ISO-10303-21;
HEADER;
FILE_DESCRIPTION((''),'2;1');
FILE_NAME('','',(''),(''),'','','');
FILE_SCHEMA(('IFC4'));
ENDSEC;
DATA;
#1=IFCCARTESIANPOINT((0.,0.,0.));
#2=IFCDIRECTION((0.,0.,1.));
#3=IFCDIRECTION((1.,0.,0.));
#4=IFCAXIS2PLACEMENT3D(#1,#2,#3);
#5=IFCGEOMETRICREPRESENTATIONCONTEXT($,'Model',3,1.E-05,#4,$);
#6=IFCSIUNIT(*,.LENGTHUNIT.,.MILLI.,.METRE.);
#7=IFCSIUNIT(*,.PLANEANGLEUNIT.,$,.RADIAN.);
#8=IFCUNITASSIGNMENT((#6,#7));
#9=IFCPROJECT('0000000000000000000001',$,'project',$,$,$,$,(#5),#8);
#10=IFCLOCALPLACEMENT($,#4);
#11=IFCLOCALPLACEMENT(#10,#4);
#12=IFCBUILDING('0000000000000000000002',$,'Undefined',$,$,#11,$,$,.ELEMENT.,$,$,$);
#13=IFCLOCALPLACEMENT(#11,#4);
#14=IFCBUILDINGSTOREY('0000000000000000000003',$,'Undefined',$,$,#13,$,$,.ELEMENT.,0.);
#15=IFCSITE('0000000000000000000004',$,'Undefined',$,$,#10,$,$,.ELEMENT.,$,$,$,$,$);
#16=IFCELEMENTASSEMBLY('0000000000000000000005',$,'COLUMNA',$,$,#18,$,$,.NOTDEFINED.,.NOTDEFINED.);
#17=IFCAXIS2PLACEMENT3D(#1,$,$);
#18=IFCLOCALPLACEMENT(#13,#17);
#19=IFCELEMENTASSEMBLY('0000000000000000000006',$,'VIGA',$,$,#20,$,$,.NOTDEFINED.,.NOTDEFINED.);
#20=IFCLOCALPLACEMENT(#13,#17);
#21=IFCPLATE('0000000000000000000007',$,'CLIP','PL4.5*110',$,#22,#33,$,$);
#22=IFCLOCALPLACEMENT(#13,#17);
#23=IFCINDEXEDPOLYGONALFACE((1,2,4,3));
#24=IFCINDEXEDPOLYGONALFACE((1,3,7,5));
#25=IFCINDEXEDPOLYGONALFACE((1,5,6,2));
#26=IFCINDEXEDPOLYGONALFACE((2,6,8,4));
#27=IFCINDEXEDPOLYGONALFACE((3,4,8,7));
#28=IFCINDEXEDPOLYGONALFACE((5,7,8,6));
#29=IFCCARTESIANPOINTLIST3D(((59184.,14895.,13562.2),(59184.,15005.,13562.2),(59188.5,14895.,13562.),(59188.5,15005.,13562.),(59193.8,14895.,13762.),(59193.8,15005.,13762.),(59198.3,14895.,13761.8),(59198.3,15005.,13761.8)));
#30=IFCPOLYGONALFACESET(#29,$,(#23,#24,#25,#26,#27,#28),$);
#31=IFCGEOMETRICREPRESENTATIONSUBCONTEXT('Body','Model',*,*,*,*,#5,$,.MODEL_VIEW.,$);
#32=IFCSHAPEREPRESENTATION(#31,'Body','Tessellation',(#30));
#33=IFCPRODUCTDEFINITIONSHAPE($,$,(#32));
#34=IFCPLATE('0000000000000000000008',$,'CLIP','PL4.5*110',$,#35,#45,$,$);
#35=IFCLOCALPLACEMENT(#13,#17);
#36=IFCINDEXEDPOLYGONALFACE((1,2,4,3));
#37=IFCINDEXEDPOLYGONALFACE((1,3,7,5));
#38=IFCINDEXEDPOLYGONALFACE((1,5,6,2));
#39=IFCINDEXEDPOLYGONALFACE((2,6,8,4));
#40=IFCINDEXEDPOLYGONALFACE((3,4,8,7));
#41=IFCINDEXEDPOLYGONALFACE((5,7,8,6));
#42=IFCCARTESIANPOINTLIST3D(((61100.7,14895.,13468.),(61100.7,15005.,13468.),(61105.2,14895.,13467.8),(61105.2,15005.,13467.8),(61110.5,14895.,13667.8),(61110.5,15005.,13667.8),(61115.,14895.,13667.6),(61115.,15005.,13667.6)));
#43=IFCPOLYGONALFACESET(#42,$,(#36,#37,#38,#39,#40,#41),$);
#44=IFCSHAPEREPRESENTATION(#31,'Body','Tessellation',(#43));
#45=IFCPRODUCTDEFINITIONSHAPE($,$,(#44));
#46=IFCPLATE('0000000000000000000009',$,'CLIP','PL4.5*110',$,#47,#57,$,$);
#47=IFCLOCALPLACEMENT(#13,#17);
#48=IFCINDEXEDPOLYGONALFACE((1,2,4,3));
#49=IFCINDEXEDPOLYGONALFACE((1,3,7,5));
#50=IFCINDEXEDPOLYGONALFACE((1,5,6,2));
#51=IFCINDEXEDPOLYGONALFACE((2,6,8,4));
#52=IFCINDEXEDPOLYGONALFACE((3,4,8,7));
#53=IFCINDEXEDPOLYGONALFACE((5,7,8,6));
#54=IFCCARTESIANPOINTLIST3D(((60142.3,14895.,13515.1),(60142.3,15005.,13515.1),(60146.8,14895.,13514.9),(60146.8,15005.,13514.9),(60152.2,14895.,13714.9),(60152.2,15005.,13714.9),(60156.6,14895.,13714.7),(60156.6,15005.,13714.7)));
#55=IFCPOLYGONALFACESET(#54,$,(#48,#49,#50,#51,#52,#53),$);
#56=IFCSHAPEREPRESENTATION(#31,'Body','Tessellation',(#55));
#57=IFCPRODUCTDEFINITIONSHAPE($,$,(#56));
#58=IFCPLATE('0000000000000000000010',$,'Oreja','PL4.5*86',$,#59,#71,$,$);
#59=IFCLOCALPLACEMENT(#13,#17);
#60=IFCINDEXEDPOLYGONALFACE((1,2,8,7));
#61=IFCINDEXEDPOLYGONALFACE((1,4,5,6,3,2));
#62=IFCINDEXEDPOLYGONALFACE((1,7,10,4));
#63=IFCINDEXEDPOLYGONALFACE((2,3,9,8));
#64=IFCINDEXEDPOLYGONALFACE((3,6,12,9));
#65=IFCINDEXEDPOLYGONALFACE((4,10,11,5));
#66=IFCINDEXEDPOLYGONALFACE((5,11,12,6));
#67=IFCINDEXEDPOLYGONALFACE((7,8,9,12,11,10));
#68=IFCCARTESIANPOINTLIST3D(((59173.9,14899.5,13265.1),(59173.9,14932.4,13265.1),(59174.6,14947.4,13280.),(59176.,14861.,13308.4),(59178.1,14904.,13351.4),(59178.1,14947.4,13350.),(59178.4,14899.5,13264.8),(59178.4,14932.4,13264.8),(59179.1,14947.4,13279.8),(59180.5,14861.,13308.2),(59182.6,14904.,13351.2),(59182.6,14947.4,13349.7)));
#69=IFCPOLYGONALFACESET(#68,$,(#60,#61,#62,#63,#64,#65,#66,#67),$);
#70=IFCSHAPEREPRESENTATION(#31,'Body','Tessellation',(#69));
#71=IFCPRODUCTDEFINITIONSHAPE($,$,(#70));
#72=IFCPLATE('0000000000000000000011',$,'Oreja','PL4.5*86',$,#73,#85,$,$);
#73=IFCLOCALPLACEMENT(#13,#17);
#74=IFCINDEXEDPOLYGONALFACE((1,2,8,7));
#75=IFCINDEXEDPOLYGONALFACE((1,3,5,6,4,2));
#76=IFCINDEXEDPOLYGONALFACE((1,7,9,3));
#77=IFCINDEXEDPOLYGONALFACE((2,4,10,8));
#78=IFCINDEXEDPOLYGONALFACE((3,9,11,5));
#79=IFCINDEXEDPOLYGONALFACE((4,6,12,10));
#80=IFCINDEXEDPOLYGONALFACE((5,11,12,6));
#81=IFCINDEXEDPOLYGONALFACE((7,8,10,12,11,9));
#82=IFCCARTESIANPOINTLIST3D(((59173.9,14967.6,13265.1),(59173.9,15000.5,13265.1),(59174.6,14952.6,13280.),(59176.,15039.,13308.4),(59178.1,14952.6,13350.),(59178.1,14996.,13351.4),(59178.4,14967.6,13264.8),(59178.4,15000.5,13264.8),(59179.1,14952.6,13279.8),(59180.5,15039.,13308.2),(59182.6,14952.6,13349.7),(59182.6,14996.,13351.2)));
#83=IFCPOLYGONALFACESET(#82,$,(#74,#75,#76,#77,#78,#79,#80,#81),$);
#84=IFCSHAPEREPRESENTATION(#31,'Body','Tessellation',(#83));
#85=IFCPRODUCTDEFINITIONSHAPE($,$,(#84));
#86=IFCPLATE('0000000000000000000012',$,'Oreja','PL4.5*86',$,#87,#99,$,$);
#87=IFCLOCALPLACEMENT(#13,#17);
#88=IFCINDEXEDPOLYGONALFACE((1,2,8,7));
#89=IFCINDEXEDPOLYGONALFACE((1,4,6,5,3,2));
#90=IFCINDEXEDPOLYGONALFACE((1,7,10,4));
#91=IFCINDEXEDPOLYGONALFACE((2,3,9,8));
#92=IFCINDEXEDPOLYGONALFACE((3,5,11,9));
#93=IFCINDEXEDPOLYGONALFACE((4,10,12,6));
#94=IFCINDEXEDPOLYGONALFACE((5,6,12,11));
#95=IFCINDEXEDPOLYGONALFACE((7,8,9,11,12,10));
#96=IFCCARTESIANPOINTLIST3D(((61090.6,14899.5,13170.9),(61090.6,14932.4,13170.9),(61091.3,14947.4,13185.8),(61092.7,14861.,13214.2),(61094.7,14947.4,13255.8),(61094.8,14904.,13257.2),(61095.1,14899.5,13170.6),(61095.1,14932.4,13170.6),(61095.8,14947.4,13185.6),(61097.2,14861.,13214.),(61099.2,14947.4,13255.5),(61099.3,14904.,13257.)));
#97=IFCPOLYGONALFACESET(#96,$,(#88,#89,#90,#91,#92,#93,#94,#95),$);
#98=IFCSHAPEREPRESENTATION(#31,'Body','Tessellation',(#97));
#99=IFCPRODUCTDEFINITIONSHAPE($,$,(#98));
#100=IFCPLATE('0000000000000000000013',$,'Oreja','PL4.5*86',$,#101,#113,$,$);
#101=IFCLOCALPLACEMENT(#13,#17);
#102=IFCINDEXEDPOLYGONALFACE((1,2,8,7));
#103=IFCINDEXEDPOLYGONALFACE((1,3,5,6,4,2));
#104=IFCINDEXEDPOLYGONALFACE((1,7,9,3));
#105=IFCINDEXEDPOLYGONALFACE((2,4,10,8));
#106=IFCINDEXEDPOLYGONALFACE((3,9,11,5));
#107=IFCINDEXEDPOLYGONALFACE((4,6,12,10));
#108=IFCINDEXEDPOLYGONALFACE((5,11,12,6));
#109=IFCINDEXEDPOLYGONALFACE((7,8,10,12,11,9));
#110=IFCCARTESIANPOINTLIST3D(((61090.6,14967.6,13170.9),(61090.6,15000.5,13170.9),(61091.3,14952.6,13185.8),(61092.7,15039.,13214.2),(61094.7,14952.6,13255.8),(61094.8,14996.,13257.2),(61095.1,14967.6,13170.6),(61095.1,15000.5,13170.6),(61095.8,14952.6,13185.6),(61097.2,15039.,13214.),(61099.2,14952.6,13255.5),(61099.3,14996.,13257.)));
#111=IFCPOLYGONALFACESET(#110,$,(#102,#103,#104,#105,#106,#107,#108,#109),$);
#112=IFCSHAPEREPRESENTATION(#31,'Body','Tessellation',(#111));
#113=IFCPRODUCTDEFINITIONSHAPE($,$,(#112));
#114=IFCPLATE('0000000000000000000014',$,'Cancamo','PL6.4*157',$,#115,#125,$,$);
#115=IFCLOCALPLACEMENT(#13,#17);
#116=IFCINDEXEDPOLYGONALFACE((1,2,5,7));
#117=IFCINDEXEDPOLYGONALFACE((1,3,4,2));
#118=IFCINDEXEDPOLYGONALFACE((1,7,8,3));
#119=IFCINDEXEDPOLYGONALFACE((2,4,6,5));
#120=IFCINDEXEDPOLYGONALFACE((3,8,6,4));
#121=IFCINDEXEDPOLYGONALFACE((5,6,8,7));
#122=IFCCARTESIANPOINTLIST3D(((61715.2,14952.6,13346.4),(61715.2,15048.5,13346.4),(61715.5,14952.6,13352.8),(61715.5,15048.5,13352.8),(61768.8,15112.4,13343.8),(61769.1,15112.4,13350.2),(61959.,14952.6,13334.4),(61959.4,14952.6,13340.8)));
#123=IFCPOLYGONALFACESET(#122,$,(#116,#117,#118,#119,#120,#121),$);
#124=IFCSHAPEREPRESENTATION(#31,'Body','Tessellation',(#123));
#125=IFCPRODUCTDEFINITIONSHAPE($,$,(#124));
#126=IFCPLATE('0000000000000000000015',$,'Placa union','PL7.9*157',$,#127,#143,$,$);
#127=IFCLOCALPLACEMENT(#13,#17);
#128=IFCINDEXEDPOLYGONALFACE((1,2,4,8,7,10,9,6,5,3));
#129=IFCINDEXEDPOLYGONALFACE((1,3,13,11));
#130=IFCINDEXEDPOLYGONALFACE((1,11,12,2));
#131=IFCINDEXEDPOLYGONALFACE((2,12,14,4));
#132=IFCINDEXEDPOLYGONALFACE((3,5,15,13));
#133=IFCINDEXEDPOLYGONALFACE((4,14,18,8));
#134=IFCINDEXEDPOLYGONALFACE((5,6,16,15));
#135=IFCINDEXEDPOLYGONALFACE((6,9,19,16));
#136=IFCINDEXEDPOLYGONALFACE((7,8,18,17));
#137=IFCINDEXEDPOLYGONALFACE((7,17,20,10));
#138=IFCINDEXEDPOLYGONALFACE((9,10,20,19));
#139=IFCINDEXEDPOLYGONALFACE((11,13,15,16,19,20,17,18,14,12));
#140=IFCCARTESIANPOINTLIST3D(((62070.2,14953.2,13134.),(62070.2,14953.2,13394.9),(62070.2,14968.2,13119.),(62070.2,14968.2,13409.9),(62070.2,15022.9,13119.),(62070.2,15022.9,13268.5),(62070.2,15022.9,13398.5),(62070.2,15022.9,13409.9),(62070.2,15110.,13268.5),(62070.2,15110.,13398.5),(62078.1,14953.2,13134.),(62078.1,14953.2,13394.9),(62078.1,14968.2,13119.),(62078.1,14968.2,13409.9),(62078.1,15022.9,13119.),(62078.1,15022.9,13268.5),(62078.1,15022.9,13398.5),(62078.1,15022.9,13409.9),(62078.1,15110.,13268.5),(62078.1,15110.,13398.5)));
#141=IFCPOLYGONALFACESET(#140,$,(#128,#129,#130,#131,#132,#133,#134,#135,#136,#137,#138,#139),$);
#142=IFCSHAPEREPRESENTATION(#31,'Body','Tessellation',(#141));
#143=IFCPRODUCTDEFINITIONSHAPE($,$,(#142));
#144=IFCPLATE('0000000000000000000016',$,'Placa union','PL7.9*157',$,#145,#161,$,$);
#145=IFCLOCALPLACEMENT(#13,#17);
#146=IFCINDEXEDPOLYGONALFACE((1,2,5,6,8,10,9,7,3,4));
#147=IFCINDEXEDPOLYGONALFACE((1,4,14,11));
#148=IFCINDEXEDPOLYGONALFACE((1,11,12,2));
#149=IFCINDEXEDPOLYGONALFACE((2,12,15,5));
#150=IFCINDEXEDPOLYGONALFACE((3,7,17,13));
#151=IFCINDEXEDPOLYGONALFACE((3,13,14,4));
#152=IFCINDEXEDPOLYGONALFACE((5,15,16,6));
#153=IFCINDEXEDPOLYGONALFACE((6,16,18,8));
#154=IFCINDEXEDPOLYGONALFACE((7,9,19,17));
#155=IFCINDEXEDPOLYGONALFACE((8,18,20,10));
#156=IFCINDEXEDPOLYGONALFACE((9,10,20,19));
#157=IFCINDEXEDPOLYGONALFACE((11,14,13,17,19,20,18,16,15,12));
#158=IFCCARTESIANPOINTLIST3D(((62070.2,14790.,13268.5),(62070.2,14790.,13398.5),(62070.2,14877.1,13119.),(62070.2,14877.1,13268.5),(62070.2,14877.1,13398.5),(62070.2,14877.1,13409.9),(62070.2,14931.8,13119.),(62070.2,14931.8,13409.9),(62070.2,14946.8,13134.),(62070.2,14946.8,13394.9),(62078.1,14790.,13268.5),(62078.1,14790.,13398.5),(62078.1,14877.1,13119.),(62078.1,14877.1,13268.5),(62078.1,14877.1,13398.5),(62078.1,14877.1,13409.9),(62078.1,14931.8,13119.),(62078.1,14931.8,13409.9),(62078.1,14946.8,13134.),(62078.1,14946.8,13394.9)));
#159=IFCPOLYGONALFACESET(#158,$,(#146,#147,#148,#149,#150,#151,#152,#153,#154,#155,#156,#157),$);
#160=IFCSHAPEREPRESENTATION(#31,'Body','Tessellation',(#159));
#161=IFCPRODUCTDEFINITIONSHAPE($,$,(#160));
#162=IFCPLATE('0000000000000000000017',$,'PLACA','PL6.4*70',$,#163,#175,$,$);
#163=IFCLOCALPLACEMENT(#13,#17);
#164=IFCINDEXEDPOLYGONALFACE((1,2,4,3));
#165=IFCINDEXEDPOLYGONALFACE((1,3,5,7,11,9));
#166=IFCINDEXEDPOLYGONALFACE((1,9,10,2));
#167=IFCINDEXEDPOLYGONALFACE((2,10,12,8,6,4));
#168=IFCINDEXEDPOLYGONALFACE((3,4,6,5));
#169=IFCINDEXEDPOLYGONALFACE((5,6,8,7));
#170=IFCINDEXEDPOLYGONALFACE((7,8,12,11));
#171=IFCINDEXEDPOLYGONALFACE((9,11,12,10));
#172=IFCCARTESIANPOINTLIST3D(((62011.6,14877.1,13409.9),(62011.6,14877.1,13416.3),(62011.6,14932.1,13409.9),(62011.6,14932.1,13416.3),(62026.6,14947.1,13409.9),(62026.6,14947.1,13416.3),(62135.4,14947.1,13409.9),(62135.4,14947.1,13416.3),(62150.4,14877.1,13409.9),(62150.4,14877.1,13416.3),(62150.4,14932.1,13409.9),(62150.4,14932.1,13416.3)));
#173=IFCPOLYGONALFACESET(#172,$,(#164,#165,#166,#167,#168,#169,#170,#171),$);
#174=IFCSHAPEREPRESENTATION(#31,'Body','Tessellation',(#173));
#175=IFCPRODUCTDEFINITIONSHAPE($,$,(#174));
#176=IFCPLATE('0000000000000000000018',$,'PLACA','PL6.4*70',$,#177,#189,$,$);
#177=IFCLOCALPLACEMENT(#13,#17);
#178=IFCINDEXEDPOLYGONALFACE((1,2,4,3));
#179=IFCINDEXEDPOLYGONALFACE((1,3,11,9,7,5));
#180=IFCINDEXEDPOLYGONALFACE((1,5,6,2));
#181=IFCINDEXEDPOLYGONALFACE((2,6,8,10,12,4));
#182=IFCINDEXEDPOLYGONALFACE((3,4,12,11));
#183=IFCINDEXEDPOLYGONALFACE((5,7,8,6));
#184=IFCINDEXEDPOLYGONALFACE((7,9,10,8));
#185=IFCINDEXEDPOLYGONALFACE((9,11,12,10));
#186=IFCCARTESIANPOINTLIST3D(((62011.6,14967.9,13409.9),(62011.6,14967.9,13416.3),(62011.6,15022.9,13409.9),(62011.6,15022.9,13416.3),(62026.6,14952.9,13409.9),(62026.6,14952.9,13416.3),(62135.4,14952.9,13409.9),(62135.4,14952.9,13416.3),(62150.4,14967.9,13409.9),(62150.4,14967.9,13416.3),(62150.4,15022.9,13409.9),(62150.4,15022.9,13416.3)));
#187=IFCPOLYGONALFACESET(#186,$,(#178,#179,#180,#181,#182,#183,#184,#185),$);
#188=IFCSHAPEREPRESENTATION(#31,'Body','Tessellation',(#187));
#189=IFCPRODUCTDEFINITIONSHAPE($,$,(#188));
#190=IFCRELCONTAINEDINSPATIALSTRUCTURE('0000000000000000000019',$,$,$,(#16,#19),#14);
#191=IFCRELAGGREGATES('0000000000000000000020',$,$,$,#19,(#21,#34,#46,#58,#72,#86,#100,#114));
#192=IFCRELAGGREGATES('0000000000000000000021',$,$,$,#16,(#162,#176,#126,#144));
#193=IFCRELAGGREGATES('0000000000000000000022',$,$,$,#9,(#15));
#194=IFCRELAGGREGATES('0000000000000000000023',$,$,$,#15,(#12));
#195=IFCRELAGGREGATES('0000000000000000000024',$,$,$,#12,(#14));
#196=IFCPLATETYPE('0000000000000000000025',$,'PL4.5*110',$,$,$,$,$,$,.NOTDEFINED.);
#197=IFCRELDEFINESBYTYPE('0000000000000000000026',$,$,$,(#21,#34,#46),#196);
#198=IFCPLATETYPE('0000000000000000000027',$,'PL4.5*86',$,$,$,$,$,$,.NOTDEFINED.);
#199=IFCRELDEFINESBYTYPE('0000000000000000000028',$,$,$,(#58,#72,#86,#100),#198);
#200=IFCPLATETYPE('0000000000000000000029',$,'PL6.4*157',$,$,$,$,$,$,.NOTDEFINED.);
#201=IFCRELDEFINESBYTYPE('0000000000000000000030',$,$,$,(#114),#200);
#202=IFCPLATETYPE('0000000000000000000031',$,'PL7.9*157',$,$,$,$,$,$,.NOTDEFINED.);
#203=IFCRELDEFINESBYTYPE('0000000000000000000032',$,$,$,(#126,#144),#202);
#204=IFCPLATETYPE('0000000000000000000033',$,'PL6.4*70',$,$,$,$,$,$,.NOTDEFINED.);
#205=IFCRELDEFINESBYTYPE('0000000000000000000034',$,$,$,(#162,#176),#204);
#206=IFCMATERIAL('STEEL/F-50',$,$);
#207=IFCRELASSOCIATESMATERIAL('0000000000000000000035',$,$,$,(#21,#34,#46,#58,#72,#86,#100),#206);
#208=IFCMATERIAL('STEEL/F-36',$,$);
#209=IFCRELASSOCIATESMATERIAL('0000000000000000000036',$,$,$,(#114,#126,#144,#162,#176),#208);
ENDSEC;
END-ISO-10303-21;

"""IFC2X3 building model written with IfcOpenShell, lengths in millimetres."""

from ifc_helpers import new_model, si_unit, frame, origin_with_axes, place, context, subcontext, project, spatial, polyline, outline, extrude, material, type_object, element, aggregate, save


model = new_model("IFC2X3")

# Units and contexts
model_context = context("Model", 3, precision=1e-05, world=origin_with_axes())
body_context = subcontext(model_context, "Body", "Model", "MODEL_VIEW")
ifc_project = project(units=[si_unit("LENGTHUNIT", "METRE", prefix="MILLI"), si_unit("PLANEANGLEUNIT", "RADIAN")], contexts=[model_context])

# Site, building, storey
site_placement = place(None, origin_with_axes())
site = spatial("IfcSite", under=ifc_project, at=site_placement, Name="Undefined", CompositionType="ELEMENT")
building_placement = place(site_placement, origin_with_axes())
building = spatial("IfcBuilding", under=site, at=building_placement, Name="Undefined", CompositionType="ELEMENT")
storey_placement = place(building_placement, origin_with_axes())
storey = spatial("IfcBuildingStorey", under=building, at=storey_placement, Name="Undefined", CompositionType="ELEMENT", Elevation=0.0)

# Element assemblies
assembly_1_placement = place(storey_placement, origin_with_axes())
assembly_1 = element("IfcElementAssembly", 1, at=assembly_1_placement, inside=storey, Name="COLUMNA", AssemblyPlace="NOTDEFINED", PredefinedType="NOTDEFINED")
assembly_2_placement = place(storey_placement, origin_with_axes())
assembly_2 = element("IfcElementAssembly", 2, at=assembly_2_placement, inside=storey, Name="VIGA", AssemblyPlace="NOTDEFINED", PredefinedType="NOTDEFINED")
ifc_material_1 = material(Name="STEEL/F-36")

# Plates
ifc_material_2 = material(Name="STEEL/F-50")
plate_type_1 = type_object("IfcPlateType", Name="PL4.5*110", PredefinedType="NOTDEFINED")
plate_1_placement = place(assembly_2_placement, frame((59186.2, 15005.0, 13562.1), z_axis=(-0.998794, 0.0, 0.04909), x_axis=(0.0, -1.0, 0.0)))
plate_1 = element("IfcPlate", 3, at=plate_1_placement, type_object=plate_type_1, material=ifc_material_2, Name="CLIP", Description="PL4.5*110", context=body_context, shape_type="SweptSolid", body=[
    extrude(outline(polyline([(0.0, 0.0), (110.0, 0.0), (110.0, 200.0), (0.0, 200.0), (0.0, 0.0)])), frame((0.0, 0.0, -2.2), z_axis=(0.0, 0.0, 1.0), x_axis=(1.0, 0.0, 0.0)), (0.0, 0.0, 1.0), 4.5),
])
plate_2_placement = place(assembly_2_placement, frame((61102.9, 15005.0, 13467.9), z_axis=(-0.998794, 0.0, 0.04909), x_axis=(0.0, -1.0, 0.0)))
plate_2 = element("IfcPlate", 4, at=plate_2_placement, type_object=plate_type_1, material=ifc_material_2, Name="CLIP", Description="PL4.5*110", context=body_context, shape_type="SweptSolid", body=[
    extrude(outline(polyline([(0.0, 0.0), (110.0, 0.0), (110.0, 200.0), (0.0, 200.0), (0.0, 0.0)])), frame((0.0, 0.0, -2.2), z_axis=(0.0, 0.0, 1.0), x_axis=(1.0, 0.0, 0.0)), (0.0, 0.0, 1.0), 4.5),
])
plate_3_placement = place(assembly_2_placement, frame((60144.6, 15005.0, 13515.0), z_axis=(-0.998794, 0.0, 0.04909), x_axis=(0.0, -1.0, 0.0)))
plate_3 = element("IfcPlate", 5, at=plate_3_placement, type_object=plate_type_1, material=ifc_material_2, Name="CLIP", Description="PL4.5*110", context=body_context, shape_type="SweptSolid", body=[
    extrude(outline(polyline([(0.0, 0.0), (110.0, 0.0), (110.0, 200.0), (0.0, 200.0), (0.0, 0.0)])), frame((0.0, 0.0, -2.2), z_axis=(0.0, 0.0, 1.0), x_axis=(1.0, 0.0, 0.0)), (0.0, 0.0, 1.0), 4.5),
])
plate_type_2 = type_object("IfcPlateType", Name="PL4.5*86", PredefinedType="NOTDEFINED")
plate_4_placement = place(assembly_2_placement, frame((59176.1, 14947.4, 13264.9), z_axis=(-0.998794, 0.0, 0.04909), x_axis=(0.000002, -1.0, 0.000044)))
plate_4 = element("IfcPlate", 6, at=plate_4_placement, type_object=plate_type_2, material=ifc_material_2, Name="Oreja", Description="PL4.5*86", context=body_context, shape_type="SweptSolid", body=[
    extrude(outline(polyline([(0.0, 15.0), (15.0, 0.0), (48.0, 0.0), (86.4, 43.4), (43.4, 86.4), (0.0, 85.0), (0.0, 15.0)])), frame((0.0, 0.0, -2.2), z_axis=(0.0, 0.0, 1.0), x_axis=(1.0, 0.0, 0.0)), (0.0, 0.0, 1.0), 4.5),
])
plate_5_placement = place(assembly_2_placement, frame((59176.1, 14952.6, 13264.9), z_axis=(0.998794, 0.0, -0.049091), x_axis=(0.000002, 1.0, 0.000044)))
plate_5 = element("IfcPlate", 7, at=plate_5_placement, type_object=plate_type_2, material=ifc_material_2, Name="Oreja", Description="PL4.5*86", context=body_context, shape_type="SweptSolid", body=[
    extrude(outline(polyline([(0.0, 15.0), (15.0, 0.0), (48.0, 0.0), (86.4, 43.4), (43.4, 86.4), (0.0, 85.0), (0.0, 15.0)])), frame((0.0, 0.0, -2.2), z_axis=(0.0, 0.0, 1.0), x_axis=(1.0, 0.0, 0.0)), (0.0, 0.0, 1.0), 4.5),
])
plate_6_placement = place(assembly_2_placement, frame((61092.8, 14947.4, 13170.7), z_axis=(-0.998794, 0.0, 0.04909), x_axis=(0.000002, -1.0, 0.000044)))
plate_6 = element("IfcPlate", 8, at=plate_6_placement, type_object=plate_type_2, material=ifc_material_2, Name="Oreja", Description="PL4.5*86", context=body_context, shape_type="SweptSolid", body=[
    extrude(outline(polyline([(0.0, 15.0), (15.0, 0.0), (48.0, 0.0), (86.4, 43.4), (43.4, 86.4), (0.0, 85.0), (0.0, 15.0)])), frame((0.0, 0.0, -2.2), z_axis=(0.0, 0.0, 1.0), x_axis=(1.0, 0.0, 0.0)), (0.0, 0.0, 1.0), 4.5),
])
plate_7_placement = place(assembly_2_placement, frame((61092.8, 14952.6, 13170.7), z_axis=(0.998794, 0.0, -0.049091), x_axis=(0.000002, 1.0, 0.000044)))
plate_7 = element("IfcPlate", 9, at=plate_7_placement, type_object=plate_type_2, material=ifc_material_2, Name="Oreja", Description="PL4.5*86", context=body_context, shape_type="SweptSolid", body=[
    extrude(outline(polyline([(0.0, 15.0), (15.0, 0.0), (48.0, 0.0), (86.4, 43.4), (43.4, 86.4), (0.0, 85.0), (0.0, 15.0)])), frame((0.0, 0.0, -2.2), z_axis=(0.0, 0.0, 1.0), x_axis=(1.0, 0.0, 0.0)), (0.0, 0.0, 1.0), 4.5),
])
plate_type_3 = type_object("IfcPlateType", Name="PL6.4*157", PredefinedType="NOTDEFINED")
plate_8_placement = place(assembly_2_placement, frame((61715.3, 14952.6, 13349.6), z_axis=(0.04909, 0.0, 0.998794), x_axis=(0.998794, 0.0, -0.049091)))
plate_8 = element("IfcPlate", 10, at=plate_8_placement, type_object=plate_type_3, material=ifc_material_1, Name="Cancamo", Description="PL6.4*157", context=body_context, shape_type="SweptSolid", body=[
    extrude(outline(polyline([(0.0, 0.0), (244.1, 0.0), (53.7, 159.9), (0.0, 95.9), (0.0, 0.0)])), frame((0.0, 0.0, -3.2), z_axis=(0.0, 0.0, 1.0), x_axis=(1.0, 0.0, 0.0)), (0.0, 0.0, 1.0), 6.4),
])
plate_type_4 = type_object("IfcPlateType", Name="PL7.9*157", PredefinedType="NOTDEFINED")
plate_9_placement = place(assembly_1_placement, frame((62074.1, 15022.9, 13409.9), z_axis=(1.0, 0.0, 0.0), x_axis=(0.0, -1.0, 0.0)))
plate_9 = element("IfcPlate", 11, at=plate_9_placement, type_object=plate_type_4, material=ifc_material_1, Name="Placa union", Description="PL7.9*157", context=body_context, shape_type="SweptSolid", body=[
    extrude(outline(polyline([(0.0, 0.0), (54.7, 0.0), (69.7, 15.0), (69.7, 275.9), (54.7, 290.9), (0.0, 290.9), (0.0, 141.3), (-87.1, 141.3), (-87.1, 11.3), (0.0, 11.3), (0.0, 0.0)])), frame((0.0, 0.0, -4.0), z_axis=(0.0, 0.0, 1.0), x_axis=(1.0, 0.0, 0.0)), (0.0, 0.0, 1.0), 7.9),
])
plate_10_placement = place(assembly_1_placement, frame((62074.1, 14877.1, 13409.9), z_axis=(-1.0, 0.0, 0.0), x_axis=(0.0, 1.0, 0.0)))
plate_10 = element("IfcPlate", 12, at=plate_10_placement, type_object=plate_type_4, material=ifc_material_1, Name="Placa union", Description="PL7.9*157", context=body_context, shape_type="SweptSolid", body=[
    extrude(outline(polyline([(0.0, 0.0), (54.7, 0.0), (69.7, 15.0), (69.7, 275.9), (54.7, 290.9), (0.0, 290.9), (0.0, 141.3), (-87.1, 141.3), (-87.1, 11.3), (0.0, 11.3), (0.0, 0.0)])), frame((0.0, 0.0, -4.0), z_axis=(0.0, 0.0, 1.0), x_axis=(1.0, 0.0, 0.0)), (0.0, 0.0, 1.0), 7.9),
])
plate_type_5 = type_object("IfcPlateType", Name="PL6.4*70", PredefinedType="NOTDEFINED")
plate_11_placement = place(assembly_1_placement, frame((62150.4, 14877.1, 13413.1), z_axis=(0.0, 0.0, 1.0), x_axis=(0.0, 1.0, 0.0)))
plate_11 = element("IfcPlate", 13, at=plate_11_placement, type_object=plate_type_5, material=ifc_material_1, Name="PLACA", Description="PL6.4*70", context=body_context, shape_type="SweptSolid", body=[
    extrude(outline(polyline([(0.0, 0.0), (55.0, 0.0), (70.0, 15.0), (70.0, 123.8), (55.0, 138.8), (0.0, 138.8), (0.0, 0.0)])), frame((0.0, 0.0, -3.2), z_axis=(0.0, 0.0, 1.0), x_axis=(1.0, 0.0, 0.0)), (0.0, 0.0, 1.0), 6.4),
])
plate_12_placement = place(assembly_1_placement, frame((62150.4, 14952.9, 13413.1), z_axis=(0.0, 0.0, 1.0), x_axis=(0.0, 1.0, 0.0)))
plate_12 = element("IfcPlate", 14, at=plate_12_placement, type_object=plate_type_5, material=ifc_material_1, Name="PLACA", Description="PL6.4*70", context=body_context, shape_type="SweptSolid", body=[
    extrude(outline(polyline([(0.0, 15.0), (15.0, 0.0), (70.0, 0.0), (70.0, 138.8), (15.0, 138.8), (0.0, 123.8), (0.0, 15.0)])), frame((0.0, 0.0, -3.2), z_axis=(0.0, 0.0, 1.0), x_axis=(1.0, 0.0, 0.0)), (0.0, 0.0, 1.0), 6.4),
])

aggregate(assembly_2, [plate_1, plate_2, plate_3, plate_4, plate_5, plate_6, plate_7, plate_8])

aggregate(assembly_1, [plate_11, plate_12, plate_9, plate_10])

save(model, "model.ifc")
